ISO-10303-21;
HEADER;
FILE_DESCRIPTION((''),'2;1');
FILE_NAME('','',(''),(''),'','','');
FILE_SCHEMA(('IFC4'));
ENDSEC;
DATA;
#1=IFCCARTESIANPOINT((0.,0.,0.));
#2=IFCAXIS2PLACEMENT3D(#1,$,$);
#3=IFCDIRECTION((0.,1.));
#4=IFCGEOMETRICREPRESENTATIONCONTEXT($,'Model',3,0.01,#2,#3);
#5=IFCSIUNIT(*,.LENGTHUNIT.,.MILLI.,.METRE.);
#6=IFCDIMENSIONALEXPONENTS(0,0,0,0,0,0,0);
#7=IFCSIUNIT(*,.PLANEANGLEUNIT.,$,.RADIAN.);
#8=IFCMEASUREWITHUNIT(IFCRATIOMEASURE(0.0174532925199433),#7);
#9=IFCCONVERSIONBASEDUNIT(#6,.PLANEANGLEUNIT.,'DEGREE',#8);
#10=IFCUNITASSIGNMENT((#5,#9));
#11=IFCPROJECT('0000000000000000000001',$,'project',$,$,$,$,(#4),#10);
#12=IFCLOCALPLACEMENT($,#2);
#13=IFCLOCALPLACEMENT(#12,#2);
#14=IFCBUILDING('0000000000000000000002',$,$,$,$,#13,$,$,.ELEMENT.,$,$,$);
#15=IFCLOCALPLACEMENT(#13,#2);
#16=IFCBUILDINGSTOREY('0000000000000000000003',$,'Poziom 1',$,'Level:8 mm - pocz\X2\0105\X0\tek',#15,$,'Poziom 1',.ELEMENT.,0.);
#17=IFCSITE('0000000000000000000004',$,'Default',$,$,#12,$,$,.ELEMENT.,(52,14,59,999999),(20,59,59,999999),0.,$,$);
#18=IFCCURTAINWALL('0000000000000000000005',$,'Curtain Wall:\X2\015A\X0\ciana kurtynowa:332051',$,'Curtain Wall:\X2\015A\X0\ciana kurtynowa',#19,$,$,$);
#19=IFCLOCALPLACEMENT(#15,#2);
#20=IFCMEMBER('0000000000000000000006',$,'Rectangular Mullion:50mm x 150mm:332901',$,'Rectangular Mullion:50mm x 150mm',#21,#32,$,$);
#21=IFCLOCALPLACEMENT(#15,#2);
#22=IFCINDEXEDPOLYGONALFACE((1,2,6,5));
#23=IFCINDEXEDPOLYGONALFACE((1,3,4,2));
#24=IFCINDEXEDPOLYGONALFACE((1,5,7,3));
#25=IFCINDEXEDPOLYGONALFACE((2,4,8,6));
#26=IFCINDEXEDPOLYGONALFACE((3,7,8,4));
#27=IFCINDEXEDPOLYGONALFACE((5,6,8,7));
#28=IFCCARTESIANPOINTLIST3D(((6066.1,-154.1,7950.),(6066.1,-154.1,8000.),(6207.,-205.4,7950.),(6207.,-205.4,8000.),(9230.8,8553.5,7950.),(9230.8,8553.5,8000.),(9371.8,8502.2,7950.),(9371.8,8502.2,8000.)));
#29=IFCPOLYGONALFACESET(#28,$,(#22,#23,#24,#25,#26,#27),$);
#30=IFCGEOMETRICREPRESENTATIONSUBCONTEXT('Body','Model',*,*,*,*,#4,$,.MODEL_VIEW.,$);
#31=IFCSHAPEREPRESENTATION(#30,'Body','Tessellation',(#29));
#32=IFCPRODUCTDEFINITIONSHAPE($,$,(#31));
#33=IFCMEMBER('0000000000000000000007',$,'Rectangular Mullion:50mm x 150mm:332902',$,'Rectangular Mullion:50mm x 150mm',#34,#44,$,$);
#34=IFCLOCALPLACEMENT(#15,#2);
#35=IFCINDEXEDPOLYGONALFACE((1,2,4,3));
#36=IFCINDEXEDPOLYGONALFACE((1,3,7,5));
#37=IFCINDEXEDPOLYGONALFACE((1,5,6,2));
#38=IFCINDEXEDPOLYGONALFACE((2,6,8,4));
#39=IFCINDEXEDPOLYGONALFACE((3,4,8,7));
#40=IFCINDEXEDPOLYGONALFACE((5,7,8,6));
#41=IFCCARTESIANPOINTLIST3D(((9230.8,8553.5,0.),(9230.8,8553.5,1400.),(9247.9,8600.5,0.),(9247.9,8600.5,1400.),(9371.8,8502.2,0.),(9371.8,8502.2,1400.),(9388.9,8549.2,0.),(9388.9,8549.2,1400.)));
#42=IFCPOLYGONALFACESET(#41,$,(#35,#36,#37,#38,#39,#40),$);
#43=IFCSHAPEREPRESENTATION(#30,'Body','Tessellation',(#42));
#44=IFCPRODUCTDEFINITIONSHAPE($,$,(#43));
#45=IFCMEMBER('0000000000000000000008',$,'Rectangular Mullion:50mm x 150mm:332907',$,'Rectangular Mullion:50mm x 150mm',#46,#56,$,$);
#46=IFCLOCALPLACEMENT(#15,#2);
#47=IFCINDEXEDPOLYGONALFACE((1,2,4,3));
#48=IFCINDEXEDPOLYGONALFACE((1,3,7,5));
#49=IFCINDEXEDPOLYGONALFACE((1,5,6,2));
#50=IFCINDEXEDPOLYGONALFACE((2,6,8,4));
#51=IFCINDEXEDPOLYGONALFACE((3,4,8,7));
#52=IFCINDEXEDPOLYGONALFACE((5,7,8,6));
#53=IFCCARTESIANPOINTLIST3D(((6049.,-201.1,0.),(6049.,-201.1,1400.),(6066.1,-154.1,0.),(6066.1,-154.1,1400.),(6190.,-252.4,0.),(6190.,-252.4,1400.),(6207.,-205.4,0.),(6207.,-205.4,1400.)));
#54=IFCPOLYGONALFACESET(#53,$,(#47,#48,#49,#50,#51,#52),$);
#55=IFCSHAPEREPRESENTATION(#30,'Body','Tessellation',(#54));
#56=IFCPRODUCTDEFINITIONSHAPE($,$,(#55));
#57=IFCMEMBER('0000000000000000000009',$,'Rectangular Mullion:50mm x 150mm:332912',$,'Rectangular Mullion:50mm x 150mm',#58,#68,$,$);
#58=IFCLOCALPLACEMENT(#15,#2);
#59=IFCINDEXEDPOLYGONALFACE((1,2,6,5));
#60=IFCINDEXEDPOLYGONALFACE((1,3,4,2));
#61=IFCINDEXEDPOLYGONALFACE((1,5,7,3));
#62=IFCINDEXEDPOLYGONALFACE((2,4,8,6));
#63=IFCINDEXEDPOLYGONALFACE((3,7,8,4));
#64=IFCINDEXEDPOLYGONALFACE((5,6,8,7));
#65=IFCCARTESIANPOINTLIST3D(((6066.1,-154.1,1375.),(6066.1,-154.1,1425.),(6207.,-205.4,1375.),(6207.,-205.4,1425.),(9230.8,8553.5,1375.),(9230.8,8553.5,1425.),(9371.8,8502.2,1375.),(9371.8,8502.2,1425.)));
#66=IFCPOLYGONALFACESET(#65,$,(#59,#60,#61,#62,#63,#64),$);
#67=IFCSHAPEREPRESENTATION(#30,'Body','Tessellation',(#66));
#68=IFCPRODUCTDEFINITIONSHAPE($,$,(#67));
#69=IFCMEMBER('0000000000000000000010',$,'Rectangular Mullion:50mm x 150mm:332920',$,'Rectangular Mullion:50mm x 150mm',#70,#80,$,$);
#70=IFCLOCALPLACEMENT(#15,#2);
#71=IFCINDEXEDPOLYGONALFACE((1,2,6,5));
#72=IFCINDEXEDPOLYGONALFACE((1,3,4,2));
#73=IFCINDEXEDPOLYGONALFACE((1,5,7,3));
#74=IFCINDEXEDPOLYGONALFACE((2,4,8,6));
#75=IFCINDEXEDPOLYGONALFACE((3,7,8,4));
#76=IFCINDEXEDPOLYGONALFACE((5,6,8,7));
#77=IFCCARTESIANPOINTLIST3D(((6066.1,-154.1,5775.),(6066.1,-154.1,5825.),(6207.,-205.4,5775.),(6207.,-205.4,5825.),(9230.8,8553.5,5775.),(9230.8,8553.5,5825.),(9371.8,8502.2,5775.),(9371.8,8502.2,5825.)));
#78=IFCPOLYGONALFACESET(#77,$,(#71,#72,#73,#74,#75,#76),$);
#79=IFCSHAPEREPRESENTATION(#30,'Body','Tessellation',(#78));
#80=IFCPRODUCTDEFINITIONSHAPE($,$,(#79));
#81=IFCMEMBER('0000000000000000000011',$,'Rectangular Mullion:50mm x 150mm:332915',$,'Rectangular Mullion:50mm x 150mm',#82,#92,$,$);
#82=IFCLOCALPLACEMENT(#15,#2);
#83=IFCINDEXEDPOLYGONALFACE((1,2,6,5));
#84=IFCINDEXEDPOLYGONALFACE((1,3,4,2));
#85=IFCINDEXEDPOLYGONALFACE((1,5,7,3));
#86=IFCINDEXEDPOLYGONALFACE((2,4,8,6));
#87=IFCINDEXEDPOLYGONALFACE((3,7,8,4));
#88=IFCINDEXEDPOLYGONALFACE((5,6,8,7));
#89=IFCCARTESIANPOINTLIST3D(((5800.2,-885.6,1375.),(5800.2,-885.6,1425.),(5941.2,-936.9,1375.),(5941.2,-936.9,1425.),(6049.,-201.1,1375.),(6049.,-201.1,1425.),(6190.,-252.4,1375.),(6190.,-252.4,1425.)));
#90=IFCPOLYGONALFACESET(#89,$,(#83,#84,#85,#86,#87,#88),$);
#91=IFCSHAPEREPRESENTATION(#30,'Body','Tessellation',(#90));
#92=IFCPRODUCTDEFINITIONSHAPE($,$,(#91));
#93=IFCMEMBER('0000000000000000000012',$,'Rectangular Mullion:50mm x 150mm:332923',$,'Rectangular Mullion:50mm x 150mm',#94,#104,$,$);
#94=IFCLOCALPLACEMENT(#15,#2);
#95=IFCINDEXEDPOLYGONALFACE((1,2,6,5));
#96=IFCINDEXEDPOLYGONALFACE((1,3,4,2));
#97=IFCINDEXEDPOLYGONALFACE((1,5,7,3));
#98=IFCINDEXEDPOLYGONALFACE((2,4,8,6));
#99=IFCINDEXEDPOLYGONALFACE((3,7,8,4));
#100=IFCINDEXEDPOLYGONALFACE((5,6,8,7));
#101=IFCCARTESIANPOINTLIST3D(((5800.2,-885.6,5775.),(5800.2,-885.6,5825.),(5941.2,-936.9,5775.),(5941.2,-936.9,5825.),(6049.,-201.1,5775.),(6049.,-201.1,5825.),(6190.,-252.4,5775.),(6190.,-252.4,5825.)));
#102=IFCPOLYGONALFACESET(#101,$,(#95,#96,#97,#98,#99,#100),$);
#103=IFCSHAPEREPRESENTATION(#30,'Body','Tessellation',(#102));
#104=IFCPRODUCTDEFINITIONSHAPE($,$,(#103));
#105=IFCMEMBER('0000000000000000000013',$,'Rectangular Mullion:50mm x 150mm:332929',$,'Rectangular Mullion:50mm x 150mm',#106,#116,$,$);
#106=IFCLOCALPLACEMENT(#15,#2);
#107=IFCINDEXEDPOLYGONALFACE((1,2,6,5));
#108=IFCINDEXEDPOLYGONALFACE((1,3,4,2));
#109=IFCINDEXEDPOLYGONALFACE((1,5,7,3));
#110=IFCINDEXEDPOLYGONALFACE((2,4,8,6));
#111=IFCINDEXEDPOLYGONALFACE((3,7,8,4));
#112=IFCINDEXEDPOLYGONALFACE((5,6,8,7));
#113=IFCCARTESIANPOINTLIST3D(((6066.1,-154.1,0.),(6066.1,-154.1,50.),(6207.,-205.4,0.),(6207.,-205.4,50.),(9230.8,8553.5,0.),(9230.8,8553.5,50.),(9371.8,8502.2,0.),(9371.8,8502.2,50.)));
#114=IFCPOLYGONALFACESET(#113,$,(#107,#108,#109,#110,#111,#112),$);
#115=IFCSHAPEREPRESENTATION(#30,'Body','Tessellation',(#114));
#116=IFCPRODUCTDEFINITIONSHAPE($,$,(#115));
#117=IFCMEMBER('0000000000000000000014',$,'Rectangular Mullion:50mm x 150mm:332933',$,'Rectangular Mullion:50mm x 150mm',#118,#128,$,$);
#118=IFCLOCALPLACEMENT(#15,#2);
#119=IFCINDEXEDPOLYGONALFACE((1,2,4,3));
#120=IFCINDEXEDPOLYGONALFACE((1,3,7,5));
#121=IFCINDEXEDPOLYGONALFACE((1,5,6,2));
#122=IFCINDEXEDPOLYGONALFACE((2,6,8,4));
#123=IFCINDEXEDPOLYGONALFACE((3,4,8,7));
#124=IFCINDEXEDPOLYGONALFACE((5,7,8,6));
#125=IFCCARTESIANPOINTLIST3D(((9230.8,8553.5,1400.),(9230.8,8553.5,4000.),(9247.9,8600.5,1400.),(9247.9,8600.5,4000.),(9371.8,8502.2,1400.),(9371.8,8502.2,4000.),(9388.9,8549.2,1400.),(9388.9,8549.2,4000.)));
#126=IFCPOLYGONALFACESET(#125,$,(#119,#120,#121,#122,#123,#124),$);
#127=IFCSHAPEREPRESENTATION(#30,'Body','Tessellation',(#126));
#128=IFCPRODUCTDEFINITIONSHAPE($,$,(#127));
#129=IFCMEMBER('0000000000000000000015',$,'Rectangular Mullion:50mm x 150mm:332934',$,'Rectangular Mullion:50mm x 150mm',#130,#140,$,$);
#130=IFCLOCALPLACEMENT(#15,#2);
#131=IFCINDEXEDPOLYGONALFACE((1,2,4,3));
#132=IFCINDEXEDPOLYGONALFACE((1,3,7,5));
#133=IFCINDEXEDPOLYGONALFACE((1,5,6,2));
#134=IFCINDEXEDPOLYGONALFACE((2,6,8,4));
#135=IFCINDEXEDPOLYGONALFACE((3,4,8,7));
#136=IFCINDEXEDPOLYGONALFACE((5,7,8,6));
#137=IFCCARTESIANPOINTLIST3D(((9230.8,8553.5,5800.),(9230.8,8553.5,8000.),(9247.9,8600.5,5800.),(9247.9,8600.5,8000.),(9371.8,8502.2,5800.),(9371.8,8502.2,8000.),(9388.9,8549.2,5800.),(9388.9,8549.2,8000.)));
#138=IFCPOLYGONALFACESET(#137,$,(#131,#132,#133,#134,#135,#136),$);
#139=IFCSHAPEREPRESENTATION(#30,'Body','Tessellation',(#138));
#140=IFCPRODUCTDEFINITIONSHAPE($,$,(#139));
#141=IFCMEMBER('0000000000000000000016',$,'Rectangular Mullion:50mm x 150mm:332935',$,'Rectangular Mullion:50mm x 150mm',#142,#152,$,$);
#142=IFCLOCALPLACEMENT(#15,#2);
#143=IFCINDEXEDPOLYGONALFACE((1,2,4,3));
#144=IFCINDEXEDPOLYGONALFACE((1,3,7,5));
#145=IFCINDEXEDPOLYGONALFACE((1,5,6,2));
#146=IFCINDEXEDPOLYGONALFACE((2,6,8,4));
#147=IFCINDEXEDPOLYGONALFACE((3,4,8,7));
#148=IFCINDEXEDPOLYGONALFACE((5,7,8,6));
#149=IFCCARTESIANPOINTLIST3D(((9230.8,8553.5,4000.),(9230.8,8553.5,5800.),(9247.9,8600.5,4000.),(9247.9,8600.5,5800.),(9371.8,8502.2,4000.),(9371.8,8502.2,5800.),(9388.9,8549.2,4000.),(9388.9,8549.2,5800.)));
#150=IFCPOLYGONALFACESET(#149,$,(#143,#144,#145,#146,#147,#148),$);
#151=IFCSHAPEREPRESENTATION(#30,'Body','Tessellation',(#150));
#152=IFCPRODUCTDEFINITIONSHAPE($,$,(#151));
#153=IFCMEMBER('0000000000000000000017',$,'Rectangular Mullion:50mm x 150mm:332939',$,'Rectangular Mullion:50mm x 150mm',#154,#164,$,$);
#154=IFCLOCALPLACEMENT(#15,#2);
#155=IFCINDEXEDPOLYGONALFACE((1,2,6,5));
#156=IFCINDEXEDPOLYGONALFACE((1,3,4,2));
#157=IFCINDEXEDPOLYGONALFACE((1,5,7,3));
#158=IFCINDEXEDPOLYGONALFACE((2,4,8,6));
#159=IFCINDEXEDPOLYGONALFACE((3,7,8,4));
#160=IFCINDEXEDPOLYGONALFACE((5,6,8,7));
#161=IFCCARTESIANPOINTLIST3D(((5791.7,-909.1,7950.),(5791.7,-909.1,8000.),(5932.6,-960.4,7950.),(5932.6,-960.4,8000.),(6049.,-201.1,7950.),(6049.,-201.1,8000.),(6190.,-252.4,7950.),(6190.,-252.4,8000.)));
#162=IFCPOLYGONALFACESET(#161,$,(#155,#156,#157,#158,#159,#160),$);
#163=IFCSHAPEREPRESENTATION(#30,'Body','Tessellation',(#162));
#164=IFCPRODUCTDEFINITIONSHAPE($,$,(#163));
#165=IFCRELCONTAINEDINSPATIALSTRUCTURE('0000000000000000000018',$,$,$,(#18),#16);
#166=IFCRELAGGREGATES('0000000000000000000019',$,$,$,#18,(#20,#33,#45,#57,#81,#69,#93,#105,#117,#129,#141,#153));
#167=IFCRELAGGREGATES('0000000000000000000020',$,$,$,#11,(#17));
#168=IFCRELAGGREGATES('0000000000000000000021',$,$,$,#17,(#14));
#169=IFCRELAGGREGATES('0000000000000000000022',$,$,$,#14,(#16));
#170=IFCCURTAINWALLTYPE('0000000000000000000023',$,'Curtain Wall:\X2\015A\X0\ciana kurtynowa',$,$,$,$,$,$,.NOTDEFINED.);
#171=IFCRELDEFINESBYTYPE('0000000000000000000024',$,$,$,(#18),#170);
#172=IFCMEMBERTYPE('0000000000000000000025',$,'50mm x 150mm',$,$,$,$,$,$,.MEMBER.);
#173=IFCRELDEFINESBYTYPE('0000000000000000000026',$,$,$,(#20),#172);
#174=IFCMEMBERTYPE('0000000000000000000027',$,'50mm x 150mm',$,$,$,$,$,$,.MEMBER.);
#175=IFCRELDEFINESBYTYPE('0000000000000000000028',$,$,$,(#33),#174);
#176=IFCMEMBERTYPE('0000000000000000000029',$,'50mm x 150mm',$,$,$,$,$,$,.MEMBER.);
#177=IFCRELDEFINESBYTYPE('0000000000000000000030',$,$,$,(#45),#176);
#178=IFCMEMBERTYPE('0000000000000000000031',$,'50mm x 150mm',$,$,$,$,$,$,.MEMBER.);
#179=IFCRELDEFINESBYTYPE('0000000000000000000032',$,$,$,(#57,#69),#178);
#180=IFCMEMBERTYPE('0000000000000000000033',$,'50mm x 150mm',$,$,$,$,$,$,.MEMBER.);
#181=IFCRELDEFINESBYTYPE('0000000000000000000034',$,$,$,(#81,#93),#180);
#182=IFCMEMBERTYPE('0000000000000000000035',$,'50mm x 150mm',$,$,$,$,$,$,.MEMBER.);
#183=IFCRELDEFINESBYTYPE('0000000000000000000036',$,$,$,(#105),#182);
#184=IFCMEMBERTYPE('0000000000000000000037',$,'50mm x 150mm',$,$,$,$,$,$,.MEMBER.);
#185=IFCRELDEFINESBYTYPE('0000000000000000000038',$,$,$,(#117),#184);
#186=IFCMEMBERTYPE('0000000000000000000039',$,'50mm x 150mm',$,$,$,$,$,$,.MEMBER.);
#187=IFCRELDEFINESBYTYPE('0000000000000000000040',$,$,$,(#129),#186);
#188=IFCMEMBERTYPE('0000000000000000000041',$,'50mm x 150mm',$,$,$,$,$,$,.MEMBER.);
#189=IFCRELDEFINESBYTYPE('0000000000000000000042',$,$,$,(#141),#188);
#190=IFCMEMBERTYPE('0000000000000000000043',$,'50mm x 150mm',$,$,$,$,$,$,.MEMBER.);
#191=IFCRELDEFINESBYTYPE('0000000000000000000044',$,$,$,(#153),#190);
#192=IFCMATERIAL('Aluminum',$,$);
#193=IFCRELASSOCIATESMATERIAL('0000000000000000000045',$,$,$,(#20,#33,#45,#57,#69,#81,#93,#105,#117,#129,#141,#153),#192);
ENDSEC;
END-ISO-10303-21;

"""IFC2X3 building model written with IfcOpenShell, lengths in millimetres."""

from ifc_helpers import new_model, entity, si_unit, converted_unit, direction, frame, origin, origin_2d_with_axis, place, context, subcontext, project, spatial, rectangle, extrude, source, transform, mapped, material, type_object, type_shapes, element, aggregate, save


model = new_model("IFC2X3")

# Units and contexts
model_context = context("Model", 3, precision=0.01, world=origin(), true_north=direction((0.0, 1.0)))
body_context = subcontext(model_context, "Body", "Model", "MODEL_VIEW")
ifc_project = project(units=[si_unit("LENGTHUNIT", "METRE", prefix="MILLI"), converted_unit("PLANEANGLEUNIT", "DEGREE", entity("IfcRatioMeasure", 0.0174532925199433), si_unit("PLANEANGLEUNIT", "RADIAN"), dimensions=[0, 0, 0, 0, 0, 0, 0])], contexts=[model_context])

# Site, building, storey
site_placement = place(None, origin())
site = spatial("IfcSite", under=ifc_project, at=site_placement, Name="Default", CompositionType="ELEMENT", RefLatitude=(52, 14, 59, 999999), RefLongitude=(20, 59, 59, 999999), RefElevation=0.0)
building_placement = place(site_placement, origin())
building = spatial("IfcBuilding", under=site, at=building_placement, CompositionType="ELEMENT")
storey_placement = place(building_placement, origin())
storey = spatial("IfcBuildingStorey", under=building, at=storey_placement, Name="Poziom 1", ObjectType="Level:8 mm - początek", LongName="Poziom 1", CompositionType="ELEMENT", Elevation=0.0)

# Curtain wall, members
curtain_wall_type = type_object("IfcCurtainWallType", Name="Curtain Wall:Ściana kurtynowa", PredefinedType="NOTDEFINED")
curtain_wall_placement = place(storey_placement, origin())
curtain_wall = element("IfcCurtainWall", 1, at=curtain_wall_placement, inside=storey, type_object=curtain_wall_type, Name="Curtain Wall:Ściana kurtynowa:332051", ObjectType="Curtain Wall:Ściana kurtynowa")
ifc_material_1 = material(Name="Aluminum")
member_type_1 = type_object("IfcMemberType", Name="50mm x 150mm", PredefinedType="MEMBER")
shared_shape_1 = source(origin(), body_context, "Body", "SweptSolid", [
    extrude(rectangle(XDim=150.0, YDim=50.0, at=origin_2d_with_axis()), frame((-25.0, 0.0, -9264.9), z_axis=(0.0, 0.0, 1.0), x_axis=(0.0, -1.0, 0.0)), (0.0, 0.0, 1.0), 9264.9),
])
type_shapes(member_type_1, [shared_shape_1])
member_1_placement = place(storey_placement, frame((9301.3, 8527.9, 8000.0), z_axis=(0.341586, 0.939851, 0.0), x_axis=(0.0, 0.0, 1.0)))
member_1 = element("IfcMember", 2, at=member_1_placement, type_object=member_type_1, material=ifc_material_1, Name="Rectangular Mullion:50mm x 150mm:332901", ObjectType="Rectangular Mullion:50mm x 150mm", context=body_context, shape_type="MappedRepresentation", body=[
    mapped(shared_shape_1, transform((0.0, 0.0, 0.0), scale=1.0)),
])
member_type_2 = type_object("IfcMemberType", Name="50mm x 150mm", PredefinedType="MEMBER")
shared_shape_2 = source(origin(), body_context, "Body", "SweptSolid", [
    extrude(rectangle(XDim=150.0, YDim=50.0, at=origin_2d_with_axis()), frame((-25.0, 0.0, -1400.0), z_axis=(0.0, 0.0, 1.0), x_axis=(0.0, -1.0, 0.0)), (0.0, 0.0, 1.0), 1400.0),
])
type_shapes(member_type_2, [shared_shape_2])
member_2_placement = place(storey_placement, frame((9318.4, 8574.9, 0.0), z_axis=(0.0, 0.0, -1.0), x_axis=(0.341586, 0.939851, 0.0)))
member_2 = element("IfcMember", 3, at=member_2_placement, type_object=member_type_2, material=ifc_material_1, Name="Rectangular Mullion:50mm x 150mm:332902", ObjectType="Rectangular Mullion:50mm x 150mm", context=body_context, shape_type="MappedRepresentation", body=[
    mapped(shared_shape_2, transform((0.0, 0.0, 0.0), scale=1.0)),
])
member_type_3 = type_object("IfcMemberType", Name="50mm x 150mm", PredefinedType="MEMBER")
shared_shape_3 = source(origin(), body_context, "Body", "SweptSolid", [
    extrude(rectangle(XDim=150.0, YDim=50.0, at=origin_2d_with_axis()), frame((0.0, 0.0, -1400.0), z_axis=(0.0, 0.0, 1.0), x_axis=(0.0, -1.0, 0.0)), (0.0, 0.0, 1.0), 1400.0),
])
type_shapes(member_type_3, [shared_shape_3])
member_3_placement = place(storey_placement, frame((6128.0, -203.2, 0.0), z_axis=(0.0, 0.0, -1.0), x_axis=(0.341586, 0.939851, 0.0)))
member_3 = element("IfcMember", 4, at=member_3_placement, type_object=member_type_3, material=ifc_material_1, Name="Rectangular Mullion:50mm x 150mm:332907", ObjectType="Rectangular Mullion:50mm x 150mm", context=body_context, shape_type="MappedRepresentation", body=[
    mapped(shared_shape_3, transform((0.0, 0.0, 0.0), scale=1.0)),
])
member_type_4 = type_object("IfcMemberType", Name="50mm x 150mm", PredefinedType="MEMBER")
shared_shape_4 = source(origin(), body_context, "Body", "SweptSolid", [
    extrude(rectangle(XDim=150.0, YDim=50.0, at=origin_2d_with_axis()), frame((0.0, 0.0, -9264.9), z_axis=(0.0, 0.0, 1.0), x_axis=(0.0, -1.0, 0.0)), (0.0, 0.0, 1.0), 9264.9),
])
type_shapes(member_type_4, [shared_shape_4])
member_4_placement = place(storey_placement, frame((9301.3, 8527.9, 1400.0), z_axis=(0.341586, 0.939851, 0.0), x_axis=(0.0, 0.0, 1.0)))
member_4 = element("IfcMember", 5, at=member_4_placement, type_object=member_type_4, material=ifc_material_1, Name="Rectangular Mullion:50mm x 150mm:332912", ObjectType="Rectangular Mullion:50mm x 150mm", context=body_context, shape_type="MappedRepresentation", body=[
    mapped(shared_shape_4, transform((0.0, 0.0, 0.0), scale=1.0)),
])
member_5_placement = place(storey_placement, frame((9301.3, 8527.9, 5800.0), z_axis=(0.341586, 0.939851, 0.0), x_axis=(0.0, 0.0, 1.0)))
member_5 = element("IfcMember", 6, at=member_5_placement, type_object=member_type_4, material=ifc_material_1, Name="Rectangular Mullion:50mm x 150mm:332920", ObjectType="Rectangular Mullion:50mm x 150mm", context=body_context, shape_type="MappedRepresentation", body=[
    mapped(shared_shape_4, transform((0.0, 0.0, 0.0), scale=1.0)),
])
member_type_5 = type_object("IfcMemberType", Name="50mm x 150mm", PredefinedType="MEMBER")
shared_shape_5 = source(origin(), body_context, "Body", "SweptSolid", [
    extrude(rectangle(XDim=150.0, YDim=50.0, at=origin_2d_with_axis()), frame((0.0, 0.0, -728.3), z_axis=(0.0, 0.0, 1.0), x_axis=(0.0, -1.0, 0.0)), (0.0, 0.0, 1.0), 728.3),
])
type_shapes(member_type_5, [shared_shape_5])
member_6_placement = place(storey_placement, frame((6119.5, -226.7, 1400.0), z_axis=(0.341586, 0.939851, 0.0), x_axis=(0.0, 0.0, 1.0)))
member_6 = element("IfcMember", 7, at=member_6_placement, type_object=member_type_5, material=ifc_material_1, Name="Rectangular Mullion:50mm x 150mm:332915", ObjectType="Rectangular Mullion:50mm x 150mm", context=body_context, shape_type="MappedRepresentation", body=[
    mapped(shared_shape_5, transform((0.0, 0.0, 0.0), scale=1.0)),
])
member_7_placement = place(storey_placement, frame((6119.5, -226.7, 5800.0), z_axis=(0.341586, 0.939851, 0.0), x_axis=(0.0, 0.0, 1.0)))
member_7 = element("IfcMember", 8, at=member_7_placement, type_object=member_type_5, material=ifc_material_1, Name="Rectangular Mullion:50mm x 150mm:332923", ObjectType="Rectangular Mullion:50mm x 150mm", context=body_context, shape_type="MappedRepresentation", body=[
    mapped(shared_shape_5, transform((0.0, 0.0, 0.0), scale=1.0)),
])
member_type_6 = type_object("IfcMemberType", Name="50mm x 150mm", PredefinedType="MEMBER")
shared_shape_6 = source(origin(), body_context, "Body", "SweptSolid", [
    extrude(rectangle(XDim=150.0, YDim=50.0, at=origin_2d_with_axis()), frame((-25.0, 0.0, -9264.9), z_axis=(0.0, 0.0, 1.0), x_axis=(0.0, -1.0, 0.0)), (0.0, 0.0, 1.0), 9264.9),
])
type_shapes(member_type_6, [shared_shape_6])
member_8_placement = place(storey_placement, frame((6136.6, -179.7, 0.0), z_axis=(-0.341586, -0.939851, 0.0), x_axis=(0.0, 0.0, -1.0)))
member_8 = element("IfcMember", 9, at=member_8_placement, type_object=member_type_6, material=ifc_material_1, Name="Rectangular Mullion:50mm x 150mm:332929", ObjectType="Rectangular Mullion:50mm x 150mm", context=body_context, shape_type="MappedRepresentation", body=[
    mapped(shared_shape_6, transform((0.0, 0.0, 0.0), scale=1.0)),
])
member_type_7 = type_object("IfcMemberType", Name="50mm x 150mm", PredefinedType="MEMBER")
shared_shape_7 = source(origin(), body_context, "Body", "SweptSolid", [
    extrude(rectangle(XDim=150.0, YDim=50.0, at=origin_2d_with_axis()), frame((-25.0, 0.0, -2600.0), z_axis=(0.0, 0.0, 1.0), x_axis=(0.0, -1.0, 0.0)), (0.0, 0.0, 1.0), 2600.0),
])
type_shapes(member_type_7, [shared_shape_7])
member_9_placement = place(storey_placement, frame((9318.4, 8574.9, 1400.0), z_axis=(0.0, 0.0, -1.0), x_axis=(0.341586, 0.939851, 0.0)))
member_9 = element("IfcMember", 10, at=member_9_placement, type_object=member_type_7, material=ifc_material_1, Name="Rectangular Mullion:50mm x 150mm:332933", ObjectType="Rectangular Mullion:50mm x 150mm", context=body_context, shape_type="MappedRepresentation", body=[
    mapped(shared_shape_7, transform((0.0, 0.0, 0.0), scale=1.0)),
])
member_type_8 = type_object("IfcMemberType", Name="50mm x 150mm", PredefinedType="MEMBER")
shared_shape_8 = source(origin(), body_context, "Body", "SweptSolid", [
    extrude(rectangle(XDim=150.0, YDim=50.0, at=origin_2d_with_axis()), frame((-25.0, 0.0, -2200.0), z_axis=(0.0, 0.0, 1.0), x_axis=(0.0, -1.0, 0.0)), (0.0, 0.0, 1.0), 2200.0),
])
type_shapes(member_type_8, [shared_shape_8])
member_10_placement = place(storey_placement, frame((9318.4, 8574.9, 5800.0), z_axis=(0.0, 0.0, -1.0), x_axis=(0.341586, 0.939851, 0.0)))
member_10 = element("IfcMember", 11, at=member_10_placement, type_object=member_type_8, material=ifc_material_1, Name="Rectangular Mullion:50mm x 150mm:332934", ObjectType="Rectangular Mullion:50mm x 150mm", context=body_context, shape_type="MappedRepresentation", body=[
    mapped(shared_shape_8, transform((0.0, 0.0, 0.0), scale=1.0)),
])
member_type_9 = type_object("IfcMemberType", Name="50mm x 150mm", PredefinedType="MEMBER")
shared_shape_9 = source(origin(), body_context, "Body", "SweptSolid", [
    extrude(rectangle(XDim=150.0, YDim=50.0, at=origin_2d_with_axis()), frame((-25.0, 0.0, -1800.0), z_axis=(0.0, 0.0, 1.0), x_axis=(0.0, -1.0, 0.0)), (0.0, 0.0, 1.0), 1800.0),
])
type_shapes(member_type_9, [shared_shape_9])
member_11_placement = place(storey_placement, frame((9318.4, 8574.9, 4000.0), z_axis=(0.0, 0.0, -1.0), x_axis=(0.341586, 0.939851, 0.0)))
member_11 = element("IfcMember", 12, at=member_11_placement, type_object=member_type_9, material=ifc_material_1, Name="Rectangular Mullion:50mm x 150mm:332935", ObjectType="Rectangular Mullion:50mm x 150mm", context=body_context, shape_type="MappedRepresentation", body=[
    mapped(shared_shape_9, transform((0.0, 0.0, 0.0), scale=1.0)),
])
member_type_10 = type_object("IfcMemberType", Name="50mm x 150mm", PredefinedType="MEMBER")
shared_shape_10 = source(origin(), body_context, "Body", "SweptSolid", [
    extrude(rectangle(XDim=150.0, YDim=50.0, at=origin_2d_with_axis()), frame((-25.0, 0.0, -753.3), z_axis=(0.0, 0.0, 1.0), x_axis=(0.0, -1.0, 0.0)), (0.0, 0.0, 1.0), 753.3),
])
type_shapes(member_type_10, [shared_shape_10])
member_12_placement = place(storey_placement, frame((6119.5, -226.7, 8000.0), z_axis=(0.341586, 0.939851, 0.0), x_axis=(0.0, 0.0, 1.0)))
member_12 = element("IfcMember", 13, at=member_12_placement, type_object=member_type_10, material=ifc_material_1, Name="Rectangular Mullion:50mm x 150mm:332939", ObjectType="Rectangular Mullion:50mm x 150mm", context=body_context, shape_type="MappedRepresentation", body=[
    mapped(shared_shape_10, transform((0.0, 0.0, 0.0), scale=1.0)),
])
aggregate(curtain_wall, [member_1, member_2, member_3, member_4, member_6, member_5, member_7, member_8, member_9, member_10, member_11, member_12])

save(model, "model.ifc")
